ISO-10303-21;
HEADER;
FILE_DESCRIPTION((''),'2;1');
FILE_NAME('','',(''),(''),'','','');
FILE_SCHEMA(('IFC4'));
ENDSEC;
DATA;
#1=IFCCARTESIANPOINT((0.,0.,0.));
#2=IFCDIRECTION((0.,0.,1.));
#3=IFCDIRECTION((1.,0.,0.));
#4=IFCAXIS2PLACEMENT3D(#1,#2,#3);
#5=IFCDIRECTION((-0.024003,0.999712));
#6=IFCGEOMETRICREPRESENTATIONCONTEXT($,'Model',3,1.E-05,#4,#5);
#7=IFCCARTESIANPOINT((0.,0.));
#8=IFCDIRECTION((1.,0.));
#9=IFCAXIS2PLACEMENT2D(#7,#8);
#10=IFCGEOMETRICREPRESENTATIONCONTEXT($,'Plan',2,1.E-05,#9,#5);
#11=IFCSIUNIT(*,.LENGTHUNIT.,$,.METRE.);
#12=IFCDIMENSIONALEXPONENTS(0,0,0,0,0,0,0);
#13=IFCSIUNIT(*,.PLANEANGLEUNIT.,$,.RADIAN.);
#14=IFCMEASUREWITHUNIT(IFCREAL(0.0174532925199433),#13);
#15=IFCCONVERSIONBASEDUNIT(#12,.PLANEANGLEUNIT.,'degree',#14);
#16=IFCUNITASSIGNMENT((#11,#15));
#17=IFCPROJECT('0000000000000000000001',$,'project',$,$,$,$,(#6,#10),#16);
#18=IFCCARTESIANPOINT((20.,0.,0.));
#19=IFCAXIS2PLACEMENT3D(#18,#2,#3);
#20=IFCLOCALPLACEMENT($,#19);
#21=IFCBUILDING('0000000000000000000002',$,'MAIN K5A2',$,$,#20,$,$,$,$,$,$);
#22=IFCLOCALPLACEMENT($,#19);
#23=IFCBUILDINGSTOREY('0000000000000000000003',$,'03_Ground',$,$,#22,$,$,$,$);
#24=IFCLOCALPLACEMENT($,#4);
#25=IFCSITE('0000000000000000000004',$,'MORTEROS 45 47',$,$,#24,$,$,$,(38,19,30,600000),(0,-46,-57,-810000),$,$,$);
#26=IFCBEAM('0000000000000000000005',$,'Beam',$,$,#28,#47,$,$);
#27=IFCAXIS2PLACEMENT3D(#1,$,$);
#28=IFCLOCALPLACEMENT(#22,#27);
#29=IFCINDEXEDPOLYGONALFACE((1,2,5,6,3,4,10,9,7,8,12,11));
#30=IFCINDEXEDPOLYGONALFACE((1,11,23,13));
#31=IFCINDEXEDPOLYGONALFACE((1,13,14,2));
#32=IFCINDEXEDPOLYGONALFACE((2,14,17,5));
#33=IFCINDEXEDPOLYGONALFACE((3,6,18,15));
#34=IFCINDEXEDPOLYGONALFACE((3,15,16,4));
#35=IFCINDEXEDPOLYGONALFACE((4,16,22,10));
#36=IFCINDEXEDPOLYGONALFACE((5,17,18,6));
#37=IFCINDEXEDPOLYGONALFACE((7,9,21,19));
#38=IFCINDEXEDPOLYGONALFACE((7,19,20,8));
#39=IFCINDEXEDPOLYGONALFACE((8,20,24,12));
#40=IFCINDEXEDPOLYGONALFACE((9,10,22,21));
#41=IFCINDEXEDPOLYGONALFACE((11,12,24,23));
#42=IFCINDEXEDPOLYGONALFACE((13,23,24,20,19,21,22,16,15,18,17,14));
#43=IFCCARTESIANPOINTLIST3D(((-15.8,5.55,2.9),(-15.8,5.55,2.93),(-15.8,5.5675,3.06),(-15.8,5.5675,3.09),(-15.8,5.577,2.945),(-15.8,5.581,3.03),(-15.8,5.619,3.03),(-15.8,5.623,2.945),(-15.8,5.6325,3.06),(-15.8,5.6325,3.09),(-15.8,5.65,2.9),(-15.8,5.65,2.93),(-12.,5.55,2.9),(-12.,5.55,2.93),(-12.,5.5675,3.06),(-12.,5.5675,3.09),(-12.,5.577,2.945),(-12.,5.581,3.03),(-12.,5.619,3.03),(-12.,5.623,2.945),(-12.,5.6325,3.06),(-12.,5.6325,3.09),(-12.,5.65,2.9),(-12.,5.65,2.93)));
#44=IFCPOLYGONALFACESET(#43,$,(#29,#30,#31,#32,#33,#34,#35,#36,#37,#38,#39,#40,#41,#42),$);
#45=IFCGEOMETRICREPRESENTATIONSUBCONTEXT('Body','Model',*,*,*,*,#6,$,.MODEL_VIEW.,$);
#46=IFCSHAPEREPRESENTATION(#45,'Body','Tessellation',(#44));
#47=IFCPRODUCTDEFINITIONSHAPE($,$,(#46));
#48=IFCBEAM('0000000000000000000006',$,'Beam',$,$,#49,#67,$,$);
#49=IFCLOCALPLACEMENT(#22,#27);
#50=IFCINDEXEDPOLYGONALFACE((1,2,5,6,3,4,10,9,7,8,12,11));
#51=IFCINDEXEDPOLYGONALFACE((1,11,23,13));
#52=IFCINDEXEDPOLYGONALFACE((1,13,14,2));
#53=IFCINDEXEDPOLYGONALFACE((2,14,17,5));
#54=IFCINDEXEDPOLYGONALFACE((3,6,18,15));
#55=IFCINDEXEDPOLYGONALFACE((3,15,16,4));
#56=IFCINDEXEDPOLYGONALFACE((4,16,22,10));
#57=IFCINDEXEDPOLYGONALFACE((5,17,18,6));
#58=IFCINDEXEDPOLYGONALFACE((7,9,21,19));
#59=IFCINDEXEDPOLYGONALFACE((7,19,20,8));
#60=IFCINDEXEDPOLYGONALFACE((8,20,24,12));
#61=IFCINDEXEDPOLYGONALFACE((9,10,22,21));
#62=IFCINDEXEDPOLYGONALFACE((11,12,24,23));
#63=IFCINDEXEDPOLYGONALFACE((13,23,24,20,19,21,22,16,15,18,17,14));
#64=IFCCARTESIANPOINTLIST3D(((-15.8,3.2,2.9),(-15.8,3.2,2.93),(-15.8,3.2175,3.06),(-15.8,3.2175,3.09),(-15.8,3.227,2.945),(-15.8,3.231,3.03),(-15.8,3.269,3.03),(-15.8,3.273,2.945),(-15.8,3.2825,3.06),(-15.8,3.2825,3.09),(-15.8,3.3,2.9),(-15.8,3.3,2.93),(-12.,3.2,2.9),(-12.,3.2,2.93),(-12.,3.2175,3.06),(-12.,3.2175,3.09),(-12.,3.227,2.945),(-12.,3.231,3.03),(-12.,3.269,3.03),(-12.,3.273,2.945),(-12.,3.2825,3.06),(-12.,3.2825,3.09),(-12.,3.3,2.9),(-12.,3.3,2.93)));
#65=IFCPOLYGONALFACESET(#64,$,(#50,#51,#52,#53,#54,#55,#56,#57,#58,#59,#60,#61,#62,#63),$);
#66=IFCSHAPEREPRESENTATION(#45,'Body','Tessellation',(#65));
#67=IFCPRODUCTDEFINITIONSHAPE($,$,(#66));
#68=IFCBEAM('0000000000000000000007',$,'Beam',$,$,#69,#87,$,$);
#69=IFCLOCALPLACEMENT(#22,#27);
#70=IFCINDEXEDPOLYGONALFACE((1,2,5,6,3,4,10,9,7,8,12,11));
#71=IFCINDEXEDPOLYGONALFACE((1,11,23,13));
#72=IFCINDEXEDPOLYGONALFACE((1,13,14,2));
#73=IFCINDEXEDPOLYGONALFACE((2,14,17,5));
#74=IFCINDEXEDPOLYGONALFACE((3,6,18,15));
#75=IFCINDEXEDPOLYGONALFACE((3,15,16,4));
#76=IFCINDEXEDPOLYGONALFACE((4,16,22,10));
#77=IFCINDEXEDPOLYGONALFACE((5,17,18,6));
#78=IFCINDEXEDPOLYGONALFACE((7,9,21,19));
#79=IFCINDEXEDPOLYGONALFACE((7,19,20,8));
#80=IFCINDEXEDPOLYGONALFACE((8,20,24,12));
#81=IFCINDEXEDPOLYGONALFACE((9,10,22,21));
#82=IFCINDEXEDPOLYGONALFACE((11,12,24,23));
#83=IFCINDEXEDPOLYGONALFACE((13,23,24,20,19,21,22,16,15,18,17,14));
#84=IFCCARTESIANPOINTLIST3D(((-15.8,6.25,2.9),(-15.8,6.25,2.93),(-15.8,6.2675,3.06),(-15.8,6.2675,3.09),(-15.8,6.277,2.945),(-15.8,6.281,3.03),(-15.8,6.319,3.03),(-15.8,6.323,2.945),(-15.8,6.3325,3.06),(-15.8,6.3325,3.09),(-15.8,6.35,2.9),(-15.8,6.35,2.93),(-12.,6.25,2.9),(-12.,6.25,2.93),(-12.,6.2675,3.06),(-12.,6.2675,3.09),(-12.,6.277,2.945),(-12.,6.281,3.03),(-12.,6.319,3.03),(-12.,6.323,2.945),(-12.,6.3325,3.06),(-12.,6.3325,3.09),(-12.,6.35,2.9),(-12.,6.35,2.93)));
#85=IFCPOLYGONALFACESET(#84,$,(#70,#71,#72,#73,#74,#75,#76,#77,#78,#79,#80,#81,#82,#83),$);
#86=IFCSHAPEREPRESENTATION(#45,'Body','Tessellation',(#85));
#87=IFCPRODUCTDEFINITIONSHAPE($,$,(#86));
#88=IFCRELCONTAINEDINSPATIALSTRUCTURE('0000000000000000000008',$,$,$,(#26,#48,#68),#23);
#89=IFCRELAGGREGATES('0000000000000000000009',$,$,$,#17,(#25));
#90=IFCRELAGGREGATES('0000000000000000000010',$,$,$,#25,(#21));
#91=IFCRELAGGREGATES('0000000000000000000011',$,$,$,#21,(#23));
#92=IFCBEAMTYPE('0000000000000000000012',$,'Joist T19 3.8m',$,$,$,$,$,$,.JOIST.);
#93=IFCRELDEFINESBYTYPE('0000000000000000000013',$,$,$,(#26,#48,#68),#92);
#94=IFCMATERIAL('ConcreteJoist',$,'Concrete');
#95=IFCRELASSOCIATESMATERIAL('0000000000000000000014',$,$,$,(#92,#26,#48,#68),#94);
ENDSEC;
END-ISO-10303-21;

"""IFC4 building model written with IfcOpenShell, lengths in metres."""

from ifc_helpers import new_model, entity, si_unit, converted_unit, direction, frame, origin_with_axes, origin_2d_with_axis, place, context, subcontext, project, spatial, indexed_curve, outline, extrude, material, material_profile, profile_set, profile_usage, type_object, element, save


model = new_model("IFC4")

# Units and contexts
model_context = context("Model", 3, precision=1e-05, world=origin_with_axes(), true_north=direction((-0.024003, 0.999712)))
plan_context = context("Plan", 2, precision=1e-05, world=origin_2d_with_axis(), true_north=direction((-0.024003, 0.999712)))
body_context_1 = subcontext(model_context, "Body", "Model", "MODEL_VIEW")
ifc_project = project(units=[si_unit("LENGTHUNIT", "METRE"), converted_unit("PLANEANGLEUNIT", "degree", entity("IfcReal", 0.0174532925199433), si_unit("PLANEANGLEUNIT", "RADIAN"), dimensions=[0, 0, 0, 0, 0, 0, 0])], contexts=[model_context, plan_context])

# Site, building, storey
site_placement = place(None, origin_with_axes())
site = spatial("IfcSite", under=ifc_project, at=site_placement, Name="MORTEROS 45 47", RefLatitude=(38, 19, 30, 600000), RefLongitude=(0, -46, -57, -810000))
building_placement = place(None, frame((20.0, 0.0, 0.0), z_axis=(0.0, 0.0, 1.0), x_axis=(1.0, 0.0, 0.0)))
building = spatial("IfcBuilding", under=site, at=building_placement, Name="MAIN K5A2")
storey_placement = place(None, frame((20.0, 0.0, 0.0), z_axis=(0.0, 0.0, 1.0), x_axis=(1.0, 0.0, 0.0)))
storey = spatial("IfcBuildingStorey", under=building, at=storey_placement, Name="03_Ground")

# Beams
ifc_material = material(Name="ConcreteJoist", Category="Concrete")
ifc_material_profile_1 = material_profile(ifc_material, outline(indexed_curve([(0.019, 0.13), (0.023, 0.045), (0.05, 0.03), (0.05, 0.0), (-0.05, 0.0), (-0.05, 0.03), (-0.023, 0.045), (-0.019, 0.13), (-0.0325, 0.16), (-0.0325, 0.19), (0.0325, 0.19), (0.0325, 0.16), (0.019, 0.13)])))
ifc_profile_set_1 = profile_set([ifc_material_profile_1], Name="JoistMaterialProfileSet")
ifc_material_profile_2 = material_profile(ifc_material, outline(indexed_curve([(0.019, 0.13), (0.023, 0.045), (0.05, 0.03), (0.05, 0.0), (-0.05, 0.0), (-0.05, 0.03), (-0.023, 0.045), (-0.019, 0.13), (-0.0325, 0.16), (-0.0325, 0.19), (0.0325, 0.19), (0.0325, 0.16), (0.019, 0.13)])))
ifc_profile_set_2 = profile_set([ifc_material_profile_2], Name="JoistMaterialProfileSet")
beam_type_1 = type_object("IfcBeamType", Name="Joist T19 3.8m", PredefinedType="JOIST", material=ifc_profile_set_2)
ifc_profile_usage_1 = profile_usage(ifc_profile_set_1)
beam_1_placement = place(None, frame((4.2, 5.6, 2.9), z_axis=(1.0, 0.0, 0.0), x_axis=(0.0, 1.0, 0.0)))
element("IfcBeam", 1, at=beam_1_placement, inside=storey, type_object=beam_type_1, material=ifc_profile_usage_1, Name="Beam", context=body_context_1, shape_type="SweptSolid", body=[
    extrude(outline(indexed_curve([(0.019, 0.13), (0.023, 0.045), (0.05, 0.03), (0.05, 0.0), (-0.05, 0.0), (-0.05, 0.03), (-0.023, 0.045), (-0.019, 0.13), (-0.0325, 0.16), (-0.0325, 0.19), (0.0325, 0.19), (0.0325, 0.16), (0.019, 0.13)])), origin_with_axes(), (0.0, 0.0, 1.0), 3.8),
])
ifc_profile_usage_2 = profile_usage(ifc_profile_set_1)
beam_2_placement = place(None, frame((4.2, 3.25, 2.9), z_axis=(1.0, 0.0, 0.0), x_axis=(0.0, 1.0, 0.0)))
element("IfcBeam", 2, at=beam_2_placement, inside=storey, type_object=beam_type_1, material=ifc_profile_usage_2, Name="Beam", context=body_context_1, shape_type="SweptSolid", body=[
    extrude(outline(indexed_curve([(0.019, 0.13), (0.023, 0.045), (0.05, 0.03), (0.05, 0.0), (-0.05, 0.0), (-0.05, 0.03), (-0.023, 0.045), (-0.019, 0.13), (-0.0325, 0.16), (-0.0325, 0.19), (0.0325, 0.19), (0.0325, 0.16), (0.019, 0.13)])), origin_with_axes(), (0.0, 0.0, 1.0), 3.8),
])
ifc_profile_usage_3 = profile_usage(ifc_profile_set_1)
beam_3_placement = place(None, frame((4.2, 6.3, 2.9), z_axis=(1.0, 0.0, 0.0), x_axis=(0.0, 1.0, 0.0)))
element("IfcBeam", 3, at=beam_3_placement, inside=storey, type_object=beam_type_1, material=ifc_profile_usage_3, Name="Beam", context=body_context_1, shape_type="SweptSolid", body=[
    extrude(outline(indexed_curve([(0.019, 0.13), (0.023, 0.045), (0.05, 0.03), (0.05, 0.0), (-0.05, 0.0), (-0.05, 0.03), (-0.023, 0.045), (-0.019, 0.13), (-0.0325, 0.16), (-0.0325, 0.19), (0.0325, 0.19), (0.0325, 0.16), (0.019, 0.13)])), origin_with_axes(), (0.0, 0.0, 1.0), 3.8),
])

save(model, "model.ifc")
